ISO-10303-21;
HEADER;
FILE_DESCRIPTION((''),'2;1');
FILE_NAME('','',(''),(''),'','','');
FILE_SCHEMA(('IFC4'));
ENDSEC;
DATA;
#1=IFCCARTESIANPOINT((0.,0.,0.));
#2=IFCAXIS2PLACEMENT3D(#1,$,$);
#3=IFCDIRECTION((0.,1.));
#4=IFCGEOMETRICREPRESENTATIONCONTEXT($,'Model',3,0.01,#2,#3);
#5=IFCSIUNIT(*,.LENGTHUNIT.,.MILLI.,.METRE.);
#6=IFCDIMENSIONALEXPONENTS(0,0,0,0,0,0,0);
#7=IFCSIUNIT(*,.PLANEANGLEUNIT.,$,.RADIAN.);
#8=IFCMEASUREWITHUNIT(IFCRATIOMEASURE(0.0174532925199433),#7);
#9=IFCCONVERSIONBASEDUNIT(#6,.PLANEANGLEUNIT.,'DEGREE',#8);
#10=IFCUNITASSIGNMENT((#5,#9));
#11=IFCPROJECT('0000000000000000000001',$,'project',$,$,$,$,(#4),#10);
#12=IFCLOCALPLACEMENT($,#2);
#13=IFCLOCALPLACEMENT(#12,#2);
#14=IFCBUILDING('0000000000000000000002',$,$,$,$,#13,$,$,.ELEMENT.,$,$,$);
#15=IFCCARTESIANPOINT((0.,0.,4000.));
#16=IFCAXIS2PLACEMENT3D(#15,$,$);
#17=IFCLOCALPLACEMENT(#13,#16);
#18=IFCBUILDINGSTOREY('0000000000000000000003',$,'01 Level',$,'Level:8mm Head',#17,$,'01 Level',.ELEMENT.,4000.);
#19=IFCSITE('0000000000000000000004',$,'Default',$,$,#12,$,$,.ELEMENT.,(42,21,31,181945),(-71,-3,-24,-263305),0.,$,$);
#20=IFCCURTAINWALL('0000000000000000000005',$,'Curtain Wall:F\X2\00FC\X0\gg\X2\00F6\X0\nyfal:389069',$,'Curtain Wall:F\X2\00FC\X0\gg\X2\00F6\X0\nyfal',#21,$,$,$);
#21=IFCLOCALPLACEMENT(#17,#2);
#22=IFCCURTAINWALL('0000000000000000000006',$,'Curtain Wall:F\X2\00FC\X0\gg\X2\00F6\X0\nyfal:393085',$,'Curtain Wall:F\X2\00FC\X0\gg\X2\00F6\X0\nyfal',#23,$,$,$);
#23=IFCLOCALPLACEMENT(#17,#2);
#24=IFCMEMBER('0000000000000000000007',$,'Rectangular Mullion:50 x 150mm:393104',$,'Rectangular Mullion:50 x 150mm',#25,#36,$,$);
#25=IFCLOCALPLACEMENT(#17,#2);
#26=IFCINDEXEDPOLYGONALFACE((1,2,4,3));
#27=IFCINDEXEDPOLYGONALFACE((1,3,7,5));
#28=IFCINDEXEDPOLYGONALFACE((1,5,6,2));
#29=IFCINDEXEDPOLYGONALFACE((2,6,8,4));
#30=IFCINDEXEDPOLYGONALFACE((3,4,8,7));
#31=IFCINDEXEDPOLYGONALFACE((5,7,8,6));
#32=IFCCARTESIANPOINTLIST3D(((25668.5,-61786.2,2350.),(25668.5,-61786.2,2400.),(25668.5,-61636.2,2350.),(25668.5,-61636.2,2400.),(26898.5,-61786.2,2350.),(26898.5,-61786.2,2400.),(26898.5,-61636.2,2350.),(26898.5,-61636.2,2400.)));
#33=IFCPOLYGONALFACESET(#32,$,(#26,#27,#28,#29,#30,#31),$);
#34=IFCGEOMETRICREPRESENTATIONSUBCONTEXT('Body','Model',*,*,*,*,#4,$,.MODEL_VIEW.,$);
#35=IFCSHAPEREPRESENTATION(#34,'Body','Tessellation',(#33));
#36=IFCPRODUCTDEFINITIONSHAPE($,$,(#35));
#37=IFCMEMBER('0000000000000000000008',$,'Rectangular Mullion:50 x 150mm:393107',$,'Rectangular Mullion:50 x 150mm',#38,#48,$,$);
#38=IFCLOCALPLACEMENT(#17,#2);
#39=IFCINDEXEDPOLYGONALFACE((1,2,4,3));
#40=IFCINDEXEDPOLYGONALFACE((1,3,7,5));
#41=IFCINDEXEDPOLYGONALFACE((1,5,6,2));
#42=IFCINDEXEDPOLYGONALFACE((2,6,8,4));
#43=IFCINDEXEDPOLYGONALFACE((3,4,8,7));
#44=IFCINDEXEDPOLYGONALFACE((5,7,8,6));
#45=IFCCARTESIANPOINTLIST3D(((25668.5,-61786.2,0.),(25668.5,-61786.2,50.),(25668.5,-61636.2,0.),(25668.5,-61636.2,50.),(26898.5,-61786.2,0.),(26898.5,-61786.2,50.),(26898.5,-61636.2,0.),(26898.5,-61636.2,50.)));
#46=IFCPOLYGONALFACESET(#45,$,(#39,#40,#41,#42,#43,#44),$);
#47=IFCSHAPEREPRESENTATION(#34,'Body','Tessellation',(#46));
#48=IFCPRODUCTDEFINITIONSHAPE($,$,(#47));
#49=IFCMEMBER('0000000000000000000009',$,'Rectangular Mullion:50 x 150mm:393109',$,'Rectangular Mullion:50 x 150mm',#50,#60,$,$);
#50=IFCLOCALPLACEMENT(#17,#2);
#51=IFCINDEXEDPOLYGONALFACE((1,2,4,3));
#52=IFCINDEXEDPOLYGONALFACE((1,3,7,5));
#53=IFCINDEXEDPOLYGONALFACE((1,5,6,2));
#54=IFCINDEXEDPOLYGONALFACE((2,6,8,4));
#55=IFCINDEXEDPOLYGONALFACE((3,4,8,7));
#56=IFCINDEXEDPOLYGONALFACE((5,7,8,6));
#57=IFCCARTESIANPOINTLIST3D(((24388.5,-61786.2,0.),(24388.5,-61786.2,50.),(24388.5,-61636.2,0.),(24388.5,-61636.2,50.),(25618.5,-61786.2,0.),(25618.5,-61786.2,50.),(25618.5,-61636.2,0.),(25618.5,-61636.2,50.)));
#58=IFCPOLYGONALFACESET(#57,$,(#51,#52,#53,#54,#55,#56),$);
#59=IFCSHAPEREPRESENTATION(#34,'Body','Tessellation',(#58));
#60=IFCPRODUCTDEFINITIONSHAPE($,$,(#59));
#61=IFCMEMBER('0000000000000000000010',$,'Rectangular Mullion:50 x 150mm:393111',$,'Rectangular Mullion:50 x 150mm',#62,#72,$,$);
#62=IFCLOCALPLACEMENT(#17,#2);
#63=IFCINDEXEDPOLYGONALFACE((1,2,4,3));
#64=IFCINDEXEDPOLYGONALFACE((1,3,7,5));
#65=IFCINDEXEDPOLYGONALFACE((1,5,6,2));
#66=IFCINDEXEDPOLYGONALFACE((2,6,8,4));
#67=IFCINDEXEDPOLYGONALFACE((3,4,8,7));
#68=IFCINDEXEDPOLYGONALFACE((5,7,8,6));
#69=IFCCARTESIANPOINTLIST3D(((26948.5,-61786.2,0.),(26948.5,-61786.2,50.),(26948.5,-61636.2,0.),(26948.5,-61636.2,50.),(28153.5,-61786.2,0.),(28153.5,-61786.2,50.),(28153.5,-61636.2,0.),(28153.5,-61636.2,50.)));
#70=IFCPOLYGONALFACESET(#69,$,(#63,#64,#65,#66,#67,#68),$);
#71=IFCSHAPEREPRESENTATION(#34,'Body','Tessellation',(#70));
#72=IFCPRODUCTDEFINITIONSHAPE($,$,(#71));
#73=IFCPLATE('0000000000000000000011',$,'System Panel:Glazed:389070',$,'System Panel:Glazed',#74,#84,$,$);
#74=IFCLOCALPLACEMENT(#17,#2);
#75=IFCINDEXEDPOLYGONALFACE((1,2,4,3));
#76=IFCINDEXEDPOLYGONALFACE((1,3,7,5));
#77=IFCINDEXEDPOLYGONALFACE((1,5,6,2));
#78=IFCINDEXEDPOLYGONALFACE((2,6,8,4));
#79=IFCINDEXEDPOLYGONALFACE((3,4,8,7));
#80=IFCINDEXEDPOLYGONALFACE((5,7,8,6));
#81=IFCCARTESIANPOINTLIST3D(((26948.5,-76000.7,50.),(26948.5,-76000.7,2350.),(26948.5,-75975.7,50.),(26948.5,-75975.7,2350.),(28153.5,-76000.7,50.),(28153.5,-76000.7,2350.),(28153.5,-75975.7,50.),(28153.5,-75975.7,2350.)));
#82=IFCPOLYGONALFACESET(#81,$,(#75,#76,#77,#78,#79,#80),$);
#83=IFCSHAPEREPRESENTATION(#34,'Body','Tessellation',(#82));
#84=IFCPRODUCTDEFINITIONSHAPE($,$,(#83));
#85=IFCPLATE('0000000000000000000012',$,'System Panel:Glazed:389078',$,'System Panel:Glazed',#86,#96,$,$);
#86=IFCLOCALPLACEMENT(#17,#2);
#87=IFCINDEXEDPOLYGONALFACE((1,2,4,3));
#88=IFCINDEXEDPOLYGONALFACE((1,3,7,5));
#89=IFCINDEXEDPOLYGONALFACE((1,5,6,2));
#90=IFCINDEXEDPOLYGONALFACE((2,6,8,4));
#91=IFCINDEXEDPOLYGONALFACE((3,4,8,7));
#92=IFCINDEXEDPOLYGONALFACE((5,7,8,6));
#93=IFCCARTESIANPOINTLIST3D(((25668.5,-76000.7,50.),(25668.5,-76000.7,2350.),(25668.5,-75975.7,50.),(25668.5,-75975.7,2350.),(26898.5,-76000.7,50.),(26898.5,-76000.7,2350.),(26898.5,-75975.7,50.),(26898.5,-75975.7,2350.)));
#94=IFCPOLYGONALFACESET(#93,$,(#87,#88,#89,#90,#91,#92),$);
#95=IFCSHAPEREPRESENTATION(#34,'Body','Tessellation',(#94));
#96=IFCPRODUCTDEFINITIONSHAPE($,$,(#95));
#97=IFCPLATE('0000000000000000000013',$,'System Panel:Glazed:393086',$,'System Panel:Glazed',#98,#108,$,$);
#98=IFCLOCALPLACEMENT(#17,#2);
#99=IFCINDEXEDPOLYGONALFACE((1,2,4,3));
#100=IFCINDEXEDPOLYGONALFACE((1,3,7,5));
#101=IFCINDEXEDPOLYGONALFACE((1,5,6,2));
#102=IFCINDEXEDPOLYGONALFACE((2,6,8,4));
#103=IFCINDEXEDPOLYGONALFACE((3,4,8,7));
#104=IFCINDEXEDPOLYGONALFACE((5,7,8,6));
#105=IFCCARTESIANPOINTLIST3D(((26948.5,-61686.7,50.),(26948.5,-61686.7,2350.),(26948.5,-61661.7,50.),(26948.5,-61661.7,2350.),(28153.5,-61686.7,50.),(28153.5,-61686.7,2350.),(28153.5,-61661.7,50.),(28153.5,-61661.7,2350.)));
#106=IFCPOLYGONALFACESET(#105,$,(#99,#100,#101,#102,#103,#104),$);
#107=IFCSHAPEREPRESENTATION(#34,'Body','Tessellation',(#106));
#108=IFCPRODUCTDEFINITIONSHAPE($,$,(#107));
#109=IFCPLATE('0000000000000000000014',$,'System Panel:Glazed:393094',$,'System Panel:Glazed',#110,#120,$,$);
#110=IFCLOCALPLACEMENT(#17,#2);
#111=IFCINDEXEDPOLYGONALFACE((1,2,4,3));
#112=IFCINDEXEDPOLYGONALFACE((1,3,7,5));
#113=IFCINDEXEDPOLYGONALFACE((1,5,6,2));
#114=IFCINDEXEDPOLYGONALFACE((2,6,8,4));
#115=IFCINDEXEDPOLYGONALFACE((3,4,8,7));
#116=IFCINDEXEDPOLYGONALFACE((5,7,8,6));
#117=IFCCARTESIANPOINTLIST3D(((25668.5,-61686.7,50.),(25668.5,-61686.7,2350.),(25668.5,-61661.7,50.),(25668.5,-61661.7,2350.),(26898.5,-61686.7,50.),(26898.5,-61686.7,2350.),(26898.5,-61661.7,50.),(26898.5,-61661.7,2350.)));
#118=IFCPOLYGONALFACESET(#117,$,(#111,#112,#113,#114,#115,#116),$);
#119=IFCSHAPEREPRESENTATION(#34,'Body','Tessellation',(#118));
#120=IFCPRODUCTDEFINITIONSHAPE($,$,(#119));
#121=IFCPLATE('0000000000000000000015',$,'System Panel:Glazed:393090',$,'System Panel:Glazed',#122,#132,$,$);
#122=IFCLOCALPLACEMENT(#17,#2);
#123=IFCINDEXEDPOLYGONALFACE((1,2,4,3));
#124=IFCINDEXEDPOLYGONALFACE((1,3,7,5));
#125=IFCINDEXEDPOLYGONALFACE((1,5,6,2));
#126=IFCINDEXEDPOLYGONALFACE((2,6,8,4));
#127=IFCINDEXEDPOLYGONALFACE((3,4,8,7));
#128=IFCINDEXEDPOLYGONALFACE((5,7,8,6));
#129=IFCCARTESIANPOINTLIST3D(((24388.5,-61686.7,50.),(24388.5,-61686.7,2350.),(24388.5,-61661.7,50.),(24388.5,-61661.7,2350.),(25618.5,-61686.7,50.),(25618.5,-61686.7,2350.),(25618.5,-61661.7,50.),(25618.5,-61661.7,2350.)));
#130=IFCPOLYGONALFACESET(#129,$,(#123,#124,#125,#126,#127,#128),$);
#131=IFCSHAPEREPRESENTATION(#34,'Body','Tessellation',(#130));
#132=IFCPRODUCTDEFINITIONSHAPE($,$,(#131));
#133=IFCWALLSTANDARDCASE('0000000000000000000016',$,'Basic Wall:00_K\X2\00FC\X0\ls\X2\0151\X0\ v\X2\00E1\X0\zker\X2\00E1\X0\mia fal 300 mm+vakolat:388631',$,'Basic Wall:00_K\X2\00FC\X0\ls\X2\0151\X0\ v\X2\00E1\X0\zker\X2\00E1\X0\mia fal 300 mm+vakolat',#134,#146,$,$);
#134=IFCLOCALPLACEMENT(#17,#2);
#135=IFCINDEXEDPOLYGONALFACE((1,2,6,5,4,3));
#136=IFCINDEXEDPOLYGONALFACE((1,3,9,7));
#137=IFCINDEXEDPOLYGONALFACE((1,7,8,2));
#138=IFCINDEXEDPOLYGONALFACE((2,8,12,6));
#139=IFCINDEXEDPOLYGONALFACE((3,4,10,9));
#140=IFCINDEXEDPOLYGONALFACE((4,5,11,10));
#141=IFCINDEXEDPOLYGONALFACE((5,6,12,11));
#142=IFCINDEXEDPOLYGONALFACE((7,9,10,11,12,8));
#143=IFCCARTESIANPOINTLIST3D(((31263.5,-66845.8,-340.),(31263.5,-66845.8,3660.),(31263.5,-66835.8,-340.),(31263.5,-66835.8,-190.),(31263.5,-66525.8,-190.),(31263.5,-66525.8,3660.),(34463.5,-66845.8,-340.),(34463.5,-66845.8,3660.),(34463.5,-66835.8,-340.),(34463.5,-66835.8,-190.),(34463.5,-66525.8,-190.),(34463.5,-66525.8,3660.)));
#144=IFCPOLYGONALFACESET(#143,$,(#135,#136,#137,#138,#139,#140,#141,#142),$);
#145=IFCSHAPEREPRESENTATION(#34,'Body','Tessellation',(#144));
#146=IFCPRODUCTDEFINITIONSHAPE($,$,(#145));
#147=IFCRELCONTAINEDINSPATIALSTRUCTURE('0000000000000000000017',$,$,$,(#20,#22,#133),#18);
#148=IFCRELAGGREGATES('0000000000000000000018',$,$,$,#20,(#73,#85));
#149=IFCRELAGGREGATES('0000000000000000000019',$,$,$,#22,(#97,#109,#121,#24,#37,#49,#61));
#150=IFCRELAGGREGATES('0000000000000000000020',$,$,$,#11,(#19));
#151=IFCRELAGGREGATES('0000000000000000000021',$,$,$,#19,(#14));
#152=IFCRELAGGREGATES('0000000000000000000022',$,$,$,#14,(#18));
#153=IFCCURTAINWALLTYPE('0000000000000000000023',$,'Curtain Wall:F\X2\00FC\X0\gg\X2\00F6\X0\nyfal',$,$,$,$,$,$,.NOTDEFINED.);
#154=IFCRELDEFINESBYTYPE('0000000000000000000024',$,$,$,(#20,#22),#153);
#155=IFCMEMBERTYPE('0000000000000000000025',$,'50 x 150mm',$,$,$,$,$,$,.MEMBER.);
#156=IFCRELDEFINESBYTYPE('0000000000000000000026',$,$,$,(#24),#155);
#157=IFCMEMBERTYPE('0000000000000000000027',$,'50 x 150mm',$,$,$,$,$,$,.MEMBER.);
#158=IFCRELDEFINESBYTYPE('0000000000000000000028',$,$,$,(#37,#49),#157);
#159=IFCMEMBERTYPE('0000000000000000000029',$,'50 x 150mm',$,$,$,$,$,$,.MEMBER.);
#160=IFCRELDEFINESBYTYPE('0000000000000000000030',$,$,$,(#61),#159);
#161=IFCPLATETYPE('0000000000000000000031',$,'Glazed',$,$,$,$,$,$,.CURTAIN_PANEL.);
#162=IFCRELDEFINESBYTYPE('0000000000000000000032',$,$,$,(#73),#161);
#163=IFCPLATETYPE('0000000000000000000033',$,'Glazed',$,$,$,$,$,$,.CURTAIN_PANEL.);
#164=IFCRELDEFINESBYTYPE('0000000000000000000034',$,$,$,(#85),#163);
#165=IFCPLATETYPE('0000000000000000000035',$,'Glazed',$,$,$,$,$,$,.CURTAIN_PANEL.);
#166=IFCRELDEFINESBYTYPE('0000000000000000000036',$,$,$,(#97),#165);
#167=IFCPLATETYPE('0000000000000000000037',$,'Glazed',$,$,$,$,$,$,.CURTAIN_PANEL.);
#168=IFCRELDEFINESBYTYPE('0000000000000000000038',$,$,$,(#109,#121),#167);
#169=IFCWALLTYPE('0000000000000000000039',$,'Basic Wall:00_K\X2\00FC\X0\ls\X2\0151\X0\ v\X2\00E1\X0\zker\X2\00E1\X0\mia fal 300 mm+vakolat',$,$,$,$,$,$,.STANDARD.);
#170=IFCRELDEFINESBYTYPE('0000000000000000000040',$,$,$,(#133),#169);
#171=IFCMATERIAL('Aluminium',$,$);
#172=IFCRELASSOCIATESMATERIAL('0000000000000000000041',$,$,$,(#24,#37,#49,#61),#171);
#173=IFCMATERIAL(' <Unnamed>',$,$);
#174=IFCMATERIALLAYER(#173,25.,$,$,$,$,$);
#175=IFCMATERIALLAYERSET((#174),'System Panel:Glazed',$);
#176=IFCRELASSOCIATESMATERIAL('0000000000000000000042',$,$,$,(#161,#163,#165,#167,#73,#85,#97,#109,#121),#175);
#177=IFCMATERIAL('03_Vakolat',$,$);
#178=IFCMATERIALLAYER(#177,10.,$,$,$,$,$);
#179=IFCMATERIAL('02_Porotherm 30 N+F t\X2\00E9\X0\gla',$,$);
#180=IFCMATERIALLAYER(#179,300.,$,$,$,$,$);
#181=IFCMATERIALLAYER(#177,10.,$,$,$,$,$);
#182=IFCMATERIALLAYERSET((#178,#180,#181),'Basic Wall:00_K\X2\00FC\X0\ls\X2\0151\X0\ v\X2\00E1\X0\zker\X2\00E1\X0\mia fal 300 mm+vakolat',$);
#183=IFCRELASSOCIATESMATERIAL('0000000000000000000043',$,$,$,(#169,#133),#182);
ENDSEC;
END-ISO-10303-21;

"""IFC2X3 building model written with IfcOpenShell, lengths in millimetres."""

from ifc_helpers import new_model, entity, si_unit, converted_unit, direction, frame, frame_2d, origin, origin_2d_with_axis, place, context, subcontext, project, spatial, polyline, rectangle, extrude, clip, bounded_halfspace, source, transform, mapped, material, layer, layer_set, layer_usage, type_object, type_shapes, element, aggregate, save


model = new_model("IFC2X3")

# Units and contexts
model_context = context("Model", 3, precision=0.01, world=origin(), true_north=direction((0.0, 1.0)))
body_context = subcontext(model_context, "Body", "Model", "MODEL_VIEW")
ifc_project = project(units=[si_unit("LENGTHUNIT", "METRE", prefix="MILLI"), converted_unit("PLANEANGLEUNIT", "DEGREE", entity("IfcRatioMeasure", 0.0174532925199433), si_unit("PLANEANGLEUNIT", "RADIAN"), dimensions=[0, 0, 0, 0, 0, 0, 0])], contexts=[model_context])

# Site, building, storey
site_placement = place(None, origin())
site = spatial("IfcSite", under=ifc_project, at=site_placement, Name="Default", CompositionType="ELEMENT", RefLatitude=(42, 21, 31, 181945), RefLongitude=(-71, -3, -24, -263305), RefElevation=0.0)
building_placement = place(site_placement, origin())
building = spatial("IfcBuilding", under=site, at=building_placement, CompositionType="ELEMENT")
storey_placement = place(building_placement, frame((0.0, 0.0, 4000.0)))
storey = spatial("IfcBuildingStorey", under=building, at=storey_placement, Name="01 Level", ObjectType="Level:8mm Head", LongName="01 Level", CompositionType="ELEMENT", Elevation=4000.0)

# Curtain walls, members
curtain_wall_type = type_object("IfcCurtainWallType", Name="Curtain Wall:Függönyfal", PredefinedType="NOTDEFINED")
curtain_wall_1_placement = place(storey_placement, frame((0.0, 0.0, -4000.0)))
curtain_wall_1 = element("IfcCurtainWall", 1, at=curtain_wall_1_placement, inside=storey, type_object=curtain_wall_type, Name="Curtain Wall:Függönyfal:389069", ObjectType="Curtain Wall:Függönyfal")
ifc_material_1 = material(Name="Aluminium")
curtain_wall_2_placement = place(storey_placement, frame((0.0, 0.0, -4000.0)))
curtain_wall_2 = element("IfcCurtainWall", 2, at=curtain_wall_2_placement, inside=storey, type_object=curtain_wall_type, Name="Curtain Wall:Függönyfal:393085", ObjectType="Curtain Wall:Függönyfal")
member_type_1 = type_object("IfcMemberType", Name="50 x 150mm", PredefinedType="MEMBER")
shared_shape_1 = source(origin(), body_context, "Body", "SweptSolid", [
    extrude(rectangle(XDim=150.0, YDim=50.0, at=origin_2d_with_axis()), frame((-25.0, 0.0, -1230.0), z_axis=(0.0, 0.0, 1.0), x_axis=(0.0, -1.0, 0.0)), (0.0, 0.0, 1.0), 1230.0),
])
type_shapes(member_type_1, [shared_shape_1])
member_1_placement = place(storey_placement, frame((25668.5, -61711.2, 2400.0), z_axis=(-1.0, 0.0, 0.0), x_axis=(0.0, 0.0, 1.0)))
member_1 = element("IfcMember", 3, at=member_1_placement, type_object=member_type_1, material=ifc_material_1, Name="Rectangular Mullion:50 x 150mm:393104", ObjectType="Rectangular Mullion:50 x 150mm", context=body_context, shape_type="MappedRepresentation", body=[
    mapped(shared_shape_1, transform((0.0, 0.0, 0.0), scale=1.0)),
])
member_type_2 = type_object("IfcMemberType", Name="50 x 150mm", PredefinedType="MEMBER")
shared_shape_2 = source(origin(), body_context, "Body", "SweptSolid", [
    extrude(rectangle(XDim=150.0, YDim=50.0, at=origin_2d_with_axis()), frame((-25.0, 0.0, -1230.0), z_axis=(0.0, 0.0, 1.0), x_axis=(0.0, -1.0, 0.0)), (0.0, 0.0, 1.0), 1230.0),
])
type_shapes(member_type_2, [shared_shape_2])
member_2_placement = place(storey_placement, frame((26898.5, -61711.2, 0.0), z_axis=(1.0, 0.0, 0.0), x_axis=(0.0, 0.0, -1.0)))
member_2 = element("IfcMember", 4, at=member_2_placement, type_object=member_type_2, material=ifc_material_1, Name="Rectangular Mullion:50 x 150mm:393107", ObjectType="Rectangular Mullion:50 x 150mm", context=body_context, shape_type="MappedRepresentation", body=[
    mapped(shared_shape_2, transform((0.0, 0.0, 0.0), scale=1.0)),
])
member_3_placement = place(storey_placement, frame((25618.5, -61711.2, 0.0), z_axis=(1.0, 0.0, 0.0), x_axis=(0.0, 0.0, -1.0)))
member_3 = element("IfcMember", 5, at=member_3_placement, type_object=member_type_2, material=ifc_material_1, Name="Rectangular Mullion:50 x 150mm:393109", ObjectType="Rectangular Mullion:50 x 150mm", context=body_context, shape_type="MappedRepresentation", body=[
    mapped(shared_shape_2, transform((0.0, 0.0, 0.0), scale=1.0)),
])
member_type_3 = type_object("IfcMemberType", Name="50 x 150mm", PredefinedType="MEMBER")
shared_shape_3 = source(origin(), body_context, "Body", "SweptSolid", [
    extrude(rectangle(XDim=150.0, YDim=50.0, at=origin_2d_with_axis()), frame((-25.0, 0.0, -1205.0), z_axis=(0.0, 0.0, 1.0), x_axis=(0.0, -1.0, 0.0)), (0.0, 0.0, 1.0), 1205.0),
])
type_shapes(member_type_3, [shared_shape_3])
member_4_placement = place(storey_placement, frame((28153.5, -61711.2, 0.0), z_axis=(1.0, 0.0, 0.0), x_axis=(0.0, 0.0, -1.0)))
member_4 = element("IfcMember", 6, at=member_4_placement, type_object=member_type_3, material=ifc_material_1, Name="Rectangular Mullion:50 x 150mm:393111", ObjectType="Rectangular Mullion:50 x 150mm", context=body_context, shape_type="MappedRepresentation", body=[
    mapped(shared_shape_3, transform((0.0, 0.0, 0.0), scale=1.0)),
])

# Plates
ifc_material_2 = material(Name=" <Unnamed>")
ifc_layer_1 = layer(ifc_material_2, 25.0)
ifc_layer_set_1 = layer_set([ifc_layer_1], Name="System Panel:Glazed")
ifc_layer_usage_1 = layer_usage(ifc_layer_set_1, "AXIS3", "POSITIVE", 0.1)
plate_type_1 = type_object("IfcPlateType", Name="Glazed", PredefinedType="CURTAIN_PANEL", material=ifc_layer_set_1)
shared_shape_4 = source(origin(), body_context, "Body", "SweptSolid", [
    extrude(rectangle(XDim=25.0, YDim=1205.0, at=origin_2d_with_axis()), frame((602.5, 12.5, 0.0), z_axis=(0.0, 0.0, 1.0), x_axis=(0.0, 1.0, 0.0)), (0.0, 0.0, 1.0), 2300.0),
])
type_shapes(plate_type_1, [shared_shape_4])
plate_1_placement = place(curtain_wall_1_placement, frame((28153.5, -75975.7, 4050.0), z_axis=(0.0, 0.0, 1.0), x_axis=(-1.0, 0.0, 0.0)))
plate_1 = element("IfcPlate", 7, at=plate_1_placement, type_object=plate_type_1, material=ifc_layer_usage_1, Name="System Panel:Glazed:389070", ObjectType="System Panel:Glazed", context=body_context, shape_type="MappedRepresentation", body=[
    mapped(shared_shape_4, transform((0.0, 0.0, 0.0), scale=1.0)),
])
ifc_layer_usage_2 = layer_usage(ifc_layer_set_1, "AXIS3", "POSITIVE", 0.1)
plate_type_2 = type_object("IfcPlateType", Name="Glazed", PredefinedType="CURTAIN_PANEL", material=ifc_layer_set_1)
shared_shape_5 = source(origin(), body_context, "Body", "SweptSolid", [
    extrude(rectangle(XDim=25.0, YDim=1230.0, at=origin_2d_with_axis()), frame((615.0, 12.5, 0.0), z_axis=(0.0, 0.0, 1.0), x_axis=(0.0, 1.0, 0.0)), (0.0, 0.0, 1.0), 2300.0),
])
type_shapes(plate_type_2, [shared_shape_5])
plate_2_placement = place(curtain_wall_1_placement, frame((26898.5, -75975.7, 4050.0), z_axis=(0.0, 0.0, 1.0), x_axis=(-1.0, 0.0, 0.0)))
plate_2 = element("IfcPlate", 8, at=plate_2_placement, type_object=plate_type_2, material=ifc_layer_usage_2, Name="System Panel:Glazed:389078", ObjectType="System Panel:Glazed", context=body_context, shape_type="MappedRepresentation", body=[
    mapped(shared_shape_5, transform((0.0, 0.0, 0.0), scale=1.0)),
])
aggregate(curtain_wall_1, [plate_1, plate_2])
ifc_layer_usage_3 = layer_usage(ifc_layer_set_1, "AXIS3", "POSITIVE", 0.1)
plate_type_3 = type_object("IfcPlateType", Name="Glazed", PredefinedType="CURTAIN_PANEL", material=ifc_layer_set_1)
shared_shape_6 = source(origin(), body_context, "Body", "SweptSolid", [
    extrude(rectangle(XDim=25.0, YDim=1205.0, at=frame_2d((0.0, 0.0), x_axis=(1.0, 0.0))), frame((602.5, 12.5, 0.0), z_axis=(0.0, 0.0, 1.0), x_axis=(0.0, 1.0, 0.0)), (0.0, 0.0, 1.0), 2300.0),
])
type_shapes(plate_type_3, [shared_shape_6])
plate_3_placement = place(curtain_wall_2_placement, frame((28153.5, -61661.7, 4050.0), z_axis=(0.0, 0.0, 1.0), x_axis=(-1.0, 0.0, 0.0)))
plate_3 = element("IfcPlate", 9, at=plate_3_placement, type_object=plate_type_3, material=ifc_layer_usage_3, Name="System Panel:Glazed:393086", ObjectType="System Panel:Glazed", context=body_context, shape_type="MappedRepresentation", body=[
    mapped(shared_shape_6, transform((0.0, 0.0, 0.0), scale=1.0)),
])
ifc_layer_usage_4 = layer_usage(ifc_layer_set_1, "AXIS3", "POSITIVE", 0.1)
plate_type_4 = type_object("IfcPlateType", Name="Glazed", PredefinedType="CURTAIN_PANEL", material=ifc_layer_set_1)
shared_shape_7 = source(origin(), body_context, "Body", "SweptSolid", [
    extrude(rectangle(XDim=25.0, YDim=1230.0, at=frame_2d((0.0, 0.0), x_axis=(1.0, 0.0))), frame((615.0, 12.5, 0.0), z_axis=(0.0, 0.0, 1.0), x_axis=(0.0, 1.0, 0.0)), (0.0, 0.0, 1.0), 2300.0),
])
type_shapes(plate_type_4, [shared_shape_7])
plate_4_placement = place(curtain_wall_2_placement, frame((26898.5, -61661.7, 4050.0), z_axis=(0.0, 0.0, 1.0), x_axis=(-1.0, 0.0, 0.0)))
plate_4 = element("IfcPlate", 10, at=plate_4_placement, type_object=plate_type_4, material=ifc_layer_usage_4, Name="System Panel:Glazed:393094", ObjectType="System Panel:Glazed", context=body_context, shape_type="MappedRepresentation", body=[
    mapped(shared_shape_7, transform((0.0, 0.0, 0.0), scale=1.0)),
])
ifc_layer_usage_5 = layer_usage(ifc_layer_set_1, "AXIS3", "POSITIVE", 0.1)
plate_5_placement = place(curtain_wall_2_placement, frame((25618.5, -61661.7, 4050.0), z_axis=(0.0, 0.0, 1.0), x_axis=(-1.0, 0.0, 0.0)))
plate_5 = element("IfcPlate", 11, at=plate_5_placement, type_object=plate_type_4, material=ifc_layer_usage_5, Name="System Panel:Glazed:393090", ObjectType="System Panel:Glazed", context=body_context, shape_type="MappedRepresentation", body=[
    mapped(shared_shape_7, transform((0.0, 0.0, 0.0), scale=1.0)),
])
aggregate(curtain_wall_2, [plate_3, plate_4, plate_5, member_1, member_2, member_3, member_4])

# Wall
ifc_material_3 = material(Name="03_Vakolat")
ifc_layer_2 = layer(ifc_material_3, 10.0)
ifc_material_4 = material(Name="02_Porotherm 30 N+F tégla")
ifc_layer_3 = layer(ifc_material_4, 300.0)
ifc_layer_4 = layer(ifc_material_3, 10.0)
ifc_layer_set_2 = layer_set([ifc_layer_2, ifc_layer_3, ifc_layer_4], Name="Basic Wall:00_Külső vázkerámia fal 300 mm+vakolat")
ifc_layer_usage_6 = layer_usage(ifc_layer_set_2, "AXIS2", "NEGATIVE", 160.0)
wall_type_1 = type_object("IfcWallType", Name="Basic Wall:00_Külső vázkerámia fal 300 mm+vakolat", PredefinedType="STANDARD", material=ifc_layer_set_2)
wall_1_placement = place(storey_placement, frame((31263.5, -66685.8, -340.0)))
element("IfcWallStandardCase", 12, at=wall_1_placement, inside=storey, type_object=wall_type_1, material=ifc_layer_usage_6, Name="Basic Wall:00_Külső vázkerámia fal 300 mm+vakolat:388631", ObjectType="Basic Wall:00_Külső vázkerámia fal 300 mm+vakolat", context=body_context, shape_type="Clipping", body=[
    clip(clip(extrude(rectangle(XDim=3200.0, YDim=320.0, at=frame_2d((1600.0, 0.0), x_axis=(-1.0, 0.0))), origin(), (0.0, 0.0, 1.0), 4000.0), bounded_halfspace(frame((3200.0, -150.0, 150.0), z_axis=(0.0, 0.0, 1.0), x_axis=(0.0, 1.0, 0.0)), True, frame((3200.0, -150.0, 150.0), z_axis=(0.0, 0.0, 1.0), x_axis=(0.0, 1.0, 0.0)), polyline([(0.0, 0.0), (310.0, 0.0), (310.0, 3200.0), (0.0, 3200.0), (0.0, 0.0)]))), bounded_halfspace(frame((0.0, -150.0, 150.0), z_axis=(0.0, -1.0, 0.0), x_axis=(0.0, 0.0, 1.0)), True, frame((0.0, -150.0, 150.0), z_axis=(0.0, -1.0, 0.0), x_axis=(0.0, 0.0, 1.0)), polyline([(0.0, 0.0), (-150.0, 0.0), (-150.0, -3200.0), (0.0, -3200.0), (0.0, 0.0)]))),
])

save(model, "model.ifc")
